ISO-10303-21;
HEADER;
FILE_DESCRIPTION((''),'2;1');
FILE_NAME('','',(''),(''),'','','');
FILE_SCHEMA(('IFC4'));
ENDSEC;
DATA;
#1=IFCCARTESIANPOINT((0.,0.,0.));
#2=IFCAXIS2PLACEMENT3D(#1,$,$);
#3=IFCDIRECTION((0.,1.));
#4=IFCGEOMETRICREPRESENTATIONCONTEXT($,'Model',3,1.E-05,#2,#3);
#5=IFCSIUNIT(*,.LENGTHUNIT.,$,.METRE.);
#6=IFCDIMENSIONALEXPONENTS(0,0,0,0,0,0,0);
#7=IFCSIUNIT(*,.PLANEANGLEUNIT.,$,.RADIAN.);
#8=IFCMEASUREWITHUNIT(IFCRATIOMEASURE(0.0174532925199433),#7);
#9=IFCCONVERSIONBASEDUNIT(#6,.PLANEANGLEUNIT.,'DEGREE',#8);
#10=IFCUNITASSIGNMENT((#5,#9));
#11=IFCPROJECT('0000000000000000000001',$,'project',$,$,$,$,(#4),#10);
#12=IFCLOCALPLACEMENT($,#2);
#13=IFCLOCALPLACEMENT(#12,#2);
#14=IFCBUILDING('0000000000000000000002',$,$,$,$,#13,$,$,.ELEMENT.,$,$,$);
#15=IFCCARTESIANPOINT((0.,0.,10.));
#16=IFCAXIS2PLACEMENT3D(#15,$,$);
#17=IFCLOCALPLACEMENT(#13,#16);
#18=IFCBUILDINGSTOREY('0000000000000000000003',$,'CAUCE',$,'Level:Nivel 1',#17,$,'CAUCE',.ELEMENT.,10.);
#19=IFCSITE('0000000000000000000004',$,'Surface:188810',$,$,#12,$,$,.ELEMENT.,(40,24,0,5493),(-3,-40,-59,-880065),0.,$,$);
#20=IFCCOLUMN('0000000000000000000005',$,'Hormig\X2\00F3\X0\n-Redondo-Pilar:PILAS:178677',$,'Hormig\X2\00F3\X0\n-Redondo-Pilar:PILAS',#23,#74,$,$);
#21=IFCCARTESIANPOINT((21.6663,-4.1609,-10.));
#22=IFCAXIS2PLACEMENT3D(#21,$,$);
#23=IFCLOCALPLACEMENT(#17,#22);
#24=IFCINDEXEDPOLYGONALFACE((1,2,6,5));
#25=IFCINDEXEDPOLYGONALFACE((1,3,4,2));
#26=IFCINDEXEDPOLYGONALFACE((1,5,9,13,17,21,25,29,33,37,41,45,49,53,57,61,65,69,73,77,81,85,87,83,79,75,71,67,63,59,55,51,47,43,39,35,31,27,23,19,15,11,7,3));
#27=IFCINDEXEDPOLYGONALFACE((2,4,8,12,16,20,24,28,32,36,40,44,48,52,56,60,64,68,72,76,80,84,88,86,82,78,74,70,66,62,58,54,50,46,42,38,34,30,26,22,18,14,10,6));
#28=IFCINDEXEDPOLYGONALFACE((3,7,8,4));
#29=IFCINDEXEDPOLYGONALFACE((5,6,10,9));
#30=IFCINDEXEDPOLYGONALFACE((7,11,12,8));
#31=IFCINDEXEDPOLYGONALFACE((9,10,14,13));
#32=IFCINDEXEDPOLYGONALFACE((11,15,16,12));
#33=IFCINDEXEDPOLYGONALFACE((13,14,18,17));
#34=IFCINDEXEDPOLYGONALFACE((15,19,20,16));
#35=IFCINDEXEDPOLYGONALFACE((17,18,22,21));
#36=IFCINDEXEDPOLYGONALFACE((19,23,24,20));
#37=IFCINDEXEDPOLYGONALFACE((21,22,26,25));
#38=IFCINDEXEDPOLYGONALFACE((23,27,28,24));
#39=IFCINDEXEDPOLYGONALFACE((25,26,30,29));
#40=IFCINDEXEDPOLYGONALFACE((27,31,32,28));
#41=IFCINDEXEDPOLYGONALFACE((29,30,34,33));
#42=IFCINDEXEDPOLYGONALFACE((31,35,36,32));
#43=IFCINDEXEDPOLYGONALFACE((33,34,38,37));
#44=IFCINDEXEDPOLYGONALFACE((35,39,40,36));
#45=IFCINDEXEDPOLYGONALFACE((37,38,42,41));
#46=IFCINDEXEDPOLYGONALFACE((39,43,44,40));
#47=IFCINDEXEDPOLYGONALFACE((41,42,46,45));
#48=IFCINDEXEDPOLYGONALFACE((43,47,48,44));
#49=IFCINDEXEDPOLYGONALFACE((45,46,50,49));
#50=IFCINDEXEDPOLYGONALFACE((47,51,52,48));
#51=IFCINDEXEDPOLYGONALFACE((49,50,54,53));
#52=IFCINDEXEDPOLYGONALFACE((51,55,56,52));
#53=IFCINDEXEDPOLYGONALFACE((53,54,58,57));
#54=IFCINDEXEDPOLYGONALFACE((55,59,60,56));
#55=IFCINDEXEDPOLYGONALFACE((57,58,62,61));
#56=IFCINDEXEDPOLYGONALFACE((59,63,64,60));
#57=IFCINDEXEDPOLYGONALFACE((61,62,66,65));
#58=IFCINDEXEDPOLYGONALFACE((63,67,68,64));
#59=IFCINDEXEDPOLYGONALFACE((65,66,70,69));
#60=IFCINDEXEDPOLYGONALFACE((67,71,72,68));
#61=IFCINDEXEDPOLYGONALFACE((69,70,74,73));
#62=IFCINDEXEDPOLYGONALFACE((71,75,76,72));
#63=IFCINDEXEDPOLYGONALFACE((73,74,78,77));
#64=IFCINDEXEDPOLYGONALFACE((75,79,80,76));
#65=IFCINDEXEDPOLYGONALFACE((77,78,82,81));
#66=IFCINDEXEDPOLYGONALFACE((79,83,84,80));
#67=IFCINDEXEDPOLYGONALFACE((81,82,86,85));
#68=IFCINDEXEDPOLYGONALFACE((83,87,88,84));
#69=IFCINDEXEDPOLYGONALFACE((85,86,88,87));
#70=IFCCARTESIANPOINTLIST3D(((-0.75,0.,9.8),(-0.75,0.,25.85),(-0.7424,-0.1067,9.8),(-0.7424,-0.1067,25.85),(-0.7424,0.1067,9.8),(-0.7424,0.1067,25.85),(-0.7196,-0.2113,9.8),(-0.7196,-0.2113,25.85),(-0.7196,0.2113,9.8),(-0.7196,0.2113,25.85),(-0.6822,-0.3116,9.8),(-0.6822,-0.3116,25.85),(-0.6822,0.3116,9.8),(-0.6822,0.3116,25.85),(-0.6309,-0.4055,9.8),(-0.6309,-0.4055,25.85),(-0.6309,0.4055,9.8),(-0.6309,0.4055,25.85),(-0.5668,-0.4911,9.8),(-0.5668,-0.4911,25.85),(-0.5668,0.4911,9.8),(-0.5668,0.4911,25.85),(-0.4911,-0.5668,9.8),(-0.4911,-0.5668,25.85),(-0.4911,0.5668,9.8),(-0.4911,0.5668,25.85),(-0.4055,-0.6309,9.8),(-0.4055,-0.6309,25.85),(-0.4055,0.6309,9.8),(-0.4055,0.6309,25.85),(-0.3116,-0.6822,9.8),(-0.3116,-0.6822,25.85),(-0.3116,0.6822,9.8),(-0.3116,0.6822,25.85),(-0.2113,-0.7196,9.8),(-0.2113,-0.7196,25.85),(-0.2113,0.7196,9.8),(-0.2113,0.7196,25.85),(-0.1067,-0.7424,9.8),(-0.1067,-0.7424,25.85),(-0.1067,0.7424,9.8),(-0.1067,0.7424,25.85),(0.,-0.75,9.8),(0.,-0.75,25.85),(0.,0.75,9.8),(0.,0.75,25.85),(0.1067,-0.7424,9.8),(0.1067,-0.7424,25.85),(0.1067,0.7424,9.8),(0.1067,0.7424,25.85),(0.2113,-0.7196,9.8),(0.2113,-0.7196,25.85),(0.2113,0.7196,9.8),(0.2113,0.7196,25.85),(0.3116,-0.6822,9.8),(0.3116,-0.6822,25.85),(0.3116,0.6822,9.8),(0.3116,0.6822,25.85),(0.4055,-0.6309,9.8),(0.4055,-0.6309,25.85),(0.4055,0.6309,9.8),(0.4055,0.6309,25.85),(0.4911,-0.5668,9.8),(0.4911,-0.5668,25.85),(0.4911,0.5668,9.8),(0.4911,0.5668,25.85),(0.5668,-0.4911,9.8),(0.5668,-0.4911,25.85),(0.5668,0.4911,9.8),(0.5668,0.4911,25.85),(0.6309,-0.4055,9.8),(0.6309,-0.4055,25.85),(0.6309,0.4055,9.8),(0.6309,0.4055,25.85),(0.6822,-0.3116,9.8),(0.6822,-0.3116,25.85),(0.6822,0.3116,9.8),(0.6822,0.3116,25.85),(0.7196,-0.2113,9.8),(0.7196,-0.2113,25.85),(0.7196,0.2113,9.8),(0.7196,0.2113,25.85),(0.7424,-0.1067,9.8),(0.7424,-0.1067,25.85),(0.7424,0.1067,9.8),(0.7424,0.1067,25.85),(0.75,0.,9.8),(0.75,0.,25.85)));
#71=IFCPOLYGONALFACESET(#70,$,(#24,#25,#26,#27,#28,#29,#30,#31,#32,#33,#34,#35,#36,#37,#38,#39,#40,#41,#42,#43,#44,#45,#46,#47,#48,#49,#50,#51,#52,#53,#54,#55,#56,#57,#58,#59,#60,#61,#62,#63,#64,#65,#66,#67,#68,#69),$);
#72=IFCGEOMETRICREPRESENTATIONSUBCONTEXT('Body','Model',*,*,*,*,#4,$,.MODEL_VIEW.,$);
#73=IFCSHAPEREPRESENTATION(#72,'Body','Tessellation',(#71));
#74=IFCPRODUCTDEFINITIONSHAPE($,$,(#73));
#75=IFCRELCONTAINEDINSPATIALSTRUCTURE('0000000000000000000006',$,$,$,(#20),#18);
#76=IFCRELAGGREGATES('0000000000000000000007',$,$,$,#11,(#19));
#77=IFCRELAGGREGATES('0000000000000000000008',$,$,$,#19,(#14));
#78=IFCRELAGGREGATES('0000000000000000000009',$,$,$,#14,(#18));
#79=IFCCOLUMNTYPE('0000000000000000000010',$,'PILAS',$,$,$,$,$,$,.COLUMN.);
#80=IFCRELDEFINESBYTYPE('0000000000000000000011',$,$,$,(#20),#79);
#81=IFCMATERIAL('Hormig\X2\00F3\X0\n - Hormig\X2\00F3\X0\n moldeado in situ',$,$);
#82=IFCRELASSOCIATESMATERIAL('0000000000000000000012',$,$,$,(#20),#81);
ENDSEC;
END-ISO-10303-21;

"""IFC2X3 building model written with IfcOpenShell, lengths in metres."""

from ifc_helpers import new_model, entity, si_unit, converted_unit, direction, frame, frame_2d, origin, place, context, subcontext, project, spatial, circle, extrude, source, transform, mapped, material, type_object, type_shapes, element, save


model = new_model("IFC2X3")

# Units and contexts
model_context = context("Model", 3, precision=1e-05, world=origin(), true_north=direction((0.0, 1.0)))
body_context = subcontext(model_context, "Body", "Model", "MODEL_VIEW")
ifc_project = project(units=[si_unit("LENGTHUNIT", "METRE"), converted_unit("PLANEANGLEUNIT", "DEGREE", entity("IfcRatioMeasure", 0.0174532925199433), si_unit("PLANEANGLEUNIT", "RADIAN"), dimensions=[0, 0, 0, 0, 0, 0, 0])], contexts=[model_context])

# Site, building, storey
site_placement = place(None, origin())
site = spatial("IfcSite", under=ifc_project, at=site_placement, Name="Surface:188810", CompositionType="ELEMENT", RefLatitude=(40, 24, 0, 5493), RefLongitude=(-3, -40, -59, -880065), RefElevation=0.0)
building_placement = place(site_placement, origin())
building = spatial("IfcBuilding", under=site, at=building_placement, CompositionType="ELEMENT")
storey_placement = place(building_placement, frame((0.0, 0.0, 10.0)))
storey = spatial("IfcBuildingStorey", under=building, at=storey_placement, Name="CAUCE", ObjectType="Level:Nivel 1", LongName="CAUCE", CompositionType="ELEMENT", Elevation=10.0)

# Column
ifc_material_1 = material(Name="Hormigón - Hormigón moldeado in situ")
column_type_1 = type_object("IfcColumnType", Name="PILAS", PredefinedType="COLUMN")
shared_shape_1 = source(origin(), body_context, "Body", "SweptSolid", [
    extrude(circle(Radius=0.75, at=frame_2d((0.0, 0.0), x_axis=(1.0, 0.0))), frame((0.0, 0.0, 9.8), z_axis=(0.0, 0.0, 1.0), x_axis=(-1.0, 0.0, 0.0)), (0.0, 0.0, 1.0), 16.05),
])
type_shapes(column_type_1, [shared_shape_1])
column_1_placement = place(storey_placement, frame((21.6663, -4.1609, -10.0)))
element("IfcColumn", 1, at=column_1_placement, inside=storey, type_object=column_type_1, material=ifc_material_1, Name="Hormigón-Redondo-Pilar:PILAS:178677", ObjectType="Hormigón-Redondo-Pilar:PILAS", context=body_context, shape_type="MappedRepresentation", body=[
    mapped(shared_shape_1, transform((0.0, 0.0, 0.0), scale=1.0)),
])

save(model, "model.ifc")
